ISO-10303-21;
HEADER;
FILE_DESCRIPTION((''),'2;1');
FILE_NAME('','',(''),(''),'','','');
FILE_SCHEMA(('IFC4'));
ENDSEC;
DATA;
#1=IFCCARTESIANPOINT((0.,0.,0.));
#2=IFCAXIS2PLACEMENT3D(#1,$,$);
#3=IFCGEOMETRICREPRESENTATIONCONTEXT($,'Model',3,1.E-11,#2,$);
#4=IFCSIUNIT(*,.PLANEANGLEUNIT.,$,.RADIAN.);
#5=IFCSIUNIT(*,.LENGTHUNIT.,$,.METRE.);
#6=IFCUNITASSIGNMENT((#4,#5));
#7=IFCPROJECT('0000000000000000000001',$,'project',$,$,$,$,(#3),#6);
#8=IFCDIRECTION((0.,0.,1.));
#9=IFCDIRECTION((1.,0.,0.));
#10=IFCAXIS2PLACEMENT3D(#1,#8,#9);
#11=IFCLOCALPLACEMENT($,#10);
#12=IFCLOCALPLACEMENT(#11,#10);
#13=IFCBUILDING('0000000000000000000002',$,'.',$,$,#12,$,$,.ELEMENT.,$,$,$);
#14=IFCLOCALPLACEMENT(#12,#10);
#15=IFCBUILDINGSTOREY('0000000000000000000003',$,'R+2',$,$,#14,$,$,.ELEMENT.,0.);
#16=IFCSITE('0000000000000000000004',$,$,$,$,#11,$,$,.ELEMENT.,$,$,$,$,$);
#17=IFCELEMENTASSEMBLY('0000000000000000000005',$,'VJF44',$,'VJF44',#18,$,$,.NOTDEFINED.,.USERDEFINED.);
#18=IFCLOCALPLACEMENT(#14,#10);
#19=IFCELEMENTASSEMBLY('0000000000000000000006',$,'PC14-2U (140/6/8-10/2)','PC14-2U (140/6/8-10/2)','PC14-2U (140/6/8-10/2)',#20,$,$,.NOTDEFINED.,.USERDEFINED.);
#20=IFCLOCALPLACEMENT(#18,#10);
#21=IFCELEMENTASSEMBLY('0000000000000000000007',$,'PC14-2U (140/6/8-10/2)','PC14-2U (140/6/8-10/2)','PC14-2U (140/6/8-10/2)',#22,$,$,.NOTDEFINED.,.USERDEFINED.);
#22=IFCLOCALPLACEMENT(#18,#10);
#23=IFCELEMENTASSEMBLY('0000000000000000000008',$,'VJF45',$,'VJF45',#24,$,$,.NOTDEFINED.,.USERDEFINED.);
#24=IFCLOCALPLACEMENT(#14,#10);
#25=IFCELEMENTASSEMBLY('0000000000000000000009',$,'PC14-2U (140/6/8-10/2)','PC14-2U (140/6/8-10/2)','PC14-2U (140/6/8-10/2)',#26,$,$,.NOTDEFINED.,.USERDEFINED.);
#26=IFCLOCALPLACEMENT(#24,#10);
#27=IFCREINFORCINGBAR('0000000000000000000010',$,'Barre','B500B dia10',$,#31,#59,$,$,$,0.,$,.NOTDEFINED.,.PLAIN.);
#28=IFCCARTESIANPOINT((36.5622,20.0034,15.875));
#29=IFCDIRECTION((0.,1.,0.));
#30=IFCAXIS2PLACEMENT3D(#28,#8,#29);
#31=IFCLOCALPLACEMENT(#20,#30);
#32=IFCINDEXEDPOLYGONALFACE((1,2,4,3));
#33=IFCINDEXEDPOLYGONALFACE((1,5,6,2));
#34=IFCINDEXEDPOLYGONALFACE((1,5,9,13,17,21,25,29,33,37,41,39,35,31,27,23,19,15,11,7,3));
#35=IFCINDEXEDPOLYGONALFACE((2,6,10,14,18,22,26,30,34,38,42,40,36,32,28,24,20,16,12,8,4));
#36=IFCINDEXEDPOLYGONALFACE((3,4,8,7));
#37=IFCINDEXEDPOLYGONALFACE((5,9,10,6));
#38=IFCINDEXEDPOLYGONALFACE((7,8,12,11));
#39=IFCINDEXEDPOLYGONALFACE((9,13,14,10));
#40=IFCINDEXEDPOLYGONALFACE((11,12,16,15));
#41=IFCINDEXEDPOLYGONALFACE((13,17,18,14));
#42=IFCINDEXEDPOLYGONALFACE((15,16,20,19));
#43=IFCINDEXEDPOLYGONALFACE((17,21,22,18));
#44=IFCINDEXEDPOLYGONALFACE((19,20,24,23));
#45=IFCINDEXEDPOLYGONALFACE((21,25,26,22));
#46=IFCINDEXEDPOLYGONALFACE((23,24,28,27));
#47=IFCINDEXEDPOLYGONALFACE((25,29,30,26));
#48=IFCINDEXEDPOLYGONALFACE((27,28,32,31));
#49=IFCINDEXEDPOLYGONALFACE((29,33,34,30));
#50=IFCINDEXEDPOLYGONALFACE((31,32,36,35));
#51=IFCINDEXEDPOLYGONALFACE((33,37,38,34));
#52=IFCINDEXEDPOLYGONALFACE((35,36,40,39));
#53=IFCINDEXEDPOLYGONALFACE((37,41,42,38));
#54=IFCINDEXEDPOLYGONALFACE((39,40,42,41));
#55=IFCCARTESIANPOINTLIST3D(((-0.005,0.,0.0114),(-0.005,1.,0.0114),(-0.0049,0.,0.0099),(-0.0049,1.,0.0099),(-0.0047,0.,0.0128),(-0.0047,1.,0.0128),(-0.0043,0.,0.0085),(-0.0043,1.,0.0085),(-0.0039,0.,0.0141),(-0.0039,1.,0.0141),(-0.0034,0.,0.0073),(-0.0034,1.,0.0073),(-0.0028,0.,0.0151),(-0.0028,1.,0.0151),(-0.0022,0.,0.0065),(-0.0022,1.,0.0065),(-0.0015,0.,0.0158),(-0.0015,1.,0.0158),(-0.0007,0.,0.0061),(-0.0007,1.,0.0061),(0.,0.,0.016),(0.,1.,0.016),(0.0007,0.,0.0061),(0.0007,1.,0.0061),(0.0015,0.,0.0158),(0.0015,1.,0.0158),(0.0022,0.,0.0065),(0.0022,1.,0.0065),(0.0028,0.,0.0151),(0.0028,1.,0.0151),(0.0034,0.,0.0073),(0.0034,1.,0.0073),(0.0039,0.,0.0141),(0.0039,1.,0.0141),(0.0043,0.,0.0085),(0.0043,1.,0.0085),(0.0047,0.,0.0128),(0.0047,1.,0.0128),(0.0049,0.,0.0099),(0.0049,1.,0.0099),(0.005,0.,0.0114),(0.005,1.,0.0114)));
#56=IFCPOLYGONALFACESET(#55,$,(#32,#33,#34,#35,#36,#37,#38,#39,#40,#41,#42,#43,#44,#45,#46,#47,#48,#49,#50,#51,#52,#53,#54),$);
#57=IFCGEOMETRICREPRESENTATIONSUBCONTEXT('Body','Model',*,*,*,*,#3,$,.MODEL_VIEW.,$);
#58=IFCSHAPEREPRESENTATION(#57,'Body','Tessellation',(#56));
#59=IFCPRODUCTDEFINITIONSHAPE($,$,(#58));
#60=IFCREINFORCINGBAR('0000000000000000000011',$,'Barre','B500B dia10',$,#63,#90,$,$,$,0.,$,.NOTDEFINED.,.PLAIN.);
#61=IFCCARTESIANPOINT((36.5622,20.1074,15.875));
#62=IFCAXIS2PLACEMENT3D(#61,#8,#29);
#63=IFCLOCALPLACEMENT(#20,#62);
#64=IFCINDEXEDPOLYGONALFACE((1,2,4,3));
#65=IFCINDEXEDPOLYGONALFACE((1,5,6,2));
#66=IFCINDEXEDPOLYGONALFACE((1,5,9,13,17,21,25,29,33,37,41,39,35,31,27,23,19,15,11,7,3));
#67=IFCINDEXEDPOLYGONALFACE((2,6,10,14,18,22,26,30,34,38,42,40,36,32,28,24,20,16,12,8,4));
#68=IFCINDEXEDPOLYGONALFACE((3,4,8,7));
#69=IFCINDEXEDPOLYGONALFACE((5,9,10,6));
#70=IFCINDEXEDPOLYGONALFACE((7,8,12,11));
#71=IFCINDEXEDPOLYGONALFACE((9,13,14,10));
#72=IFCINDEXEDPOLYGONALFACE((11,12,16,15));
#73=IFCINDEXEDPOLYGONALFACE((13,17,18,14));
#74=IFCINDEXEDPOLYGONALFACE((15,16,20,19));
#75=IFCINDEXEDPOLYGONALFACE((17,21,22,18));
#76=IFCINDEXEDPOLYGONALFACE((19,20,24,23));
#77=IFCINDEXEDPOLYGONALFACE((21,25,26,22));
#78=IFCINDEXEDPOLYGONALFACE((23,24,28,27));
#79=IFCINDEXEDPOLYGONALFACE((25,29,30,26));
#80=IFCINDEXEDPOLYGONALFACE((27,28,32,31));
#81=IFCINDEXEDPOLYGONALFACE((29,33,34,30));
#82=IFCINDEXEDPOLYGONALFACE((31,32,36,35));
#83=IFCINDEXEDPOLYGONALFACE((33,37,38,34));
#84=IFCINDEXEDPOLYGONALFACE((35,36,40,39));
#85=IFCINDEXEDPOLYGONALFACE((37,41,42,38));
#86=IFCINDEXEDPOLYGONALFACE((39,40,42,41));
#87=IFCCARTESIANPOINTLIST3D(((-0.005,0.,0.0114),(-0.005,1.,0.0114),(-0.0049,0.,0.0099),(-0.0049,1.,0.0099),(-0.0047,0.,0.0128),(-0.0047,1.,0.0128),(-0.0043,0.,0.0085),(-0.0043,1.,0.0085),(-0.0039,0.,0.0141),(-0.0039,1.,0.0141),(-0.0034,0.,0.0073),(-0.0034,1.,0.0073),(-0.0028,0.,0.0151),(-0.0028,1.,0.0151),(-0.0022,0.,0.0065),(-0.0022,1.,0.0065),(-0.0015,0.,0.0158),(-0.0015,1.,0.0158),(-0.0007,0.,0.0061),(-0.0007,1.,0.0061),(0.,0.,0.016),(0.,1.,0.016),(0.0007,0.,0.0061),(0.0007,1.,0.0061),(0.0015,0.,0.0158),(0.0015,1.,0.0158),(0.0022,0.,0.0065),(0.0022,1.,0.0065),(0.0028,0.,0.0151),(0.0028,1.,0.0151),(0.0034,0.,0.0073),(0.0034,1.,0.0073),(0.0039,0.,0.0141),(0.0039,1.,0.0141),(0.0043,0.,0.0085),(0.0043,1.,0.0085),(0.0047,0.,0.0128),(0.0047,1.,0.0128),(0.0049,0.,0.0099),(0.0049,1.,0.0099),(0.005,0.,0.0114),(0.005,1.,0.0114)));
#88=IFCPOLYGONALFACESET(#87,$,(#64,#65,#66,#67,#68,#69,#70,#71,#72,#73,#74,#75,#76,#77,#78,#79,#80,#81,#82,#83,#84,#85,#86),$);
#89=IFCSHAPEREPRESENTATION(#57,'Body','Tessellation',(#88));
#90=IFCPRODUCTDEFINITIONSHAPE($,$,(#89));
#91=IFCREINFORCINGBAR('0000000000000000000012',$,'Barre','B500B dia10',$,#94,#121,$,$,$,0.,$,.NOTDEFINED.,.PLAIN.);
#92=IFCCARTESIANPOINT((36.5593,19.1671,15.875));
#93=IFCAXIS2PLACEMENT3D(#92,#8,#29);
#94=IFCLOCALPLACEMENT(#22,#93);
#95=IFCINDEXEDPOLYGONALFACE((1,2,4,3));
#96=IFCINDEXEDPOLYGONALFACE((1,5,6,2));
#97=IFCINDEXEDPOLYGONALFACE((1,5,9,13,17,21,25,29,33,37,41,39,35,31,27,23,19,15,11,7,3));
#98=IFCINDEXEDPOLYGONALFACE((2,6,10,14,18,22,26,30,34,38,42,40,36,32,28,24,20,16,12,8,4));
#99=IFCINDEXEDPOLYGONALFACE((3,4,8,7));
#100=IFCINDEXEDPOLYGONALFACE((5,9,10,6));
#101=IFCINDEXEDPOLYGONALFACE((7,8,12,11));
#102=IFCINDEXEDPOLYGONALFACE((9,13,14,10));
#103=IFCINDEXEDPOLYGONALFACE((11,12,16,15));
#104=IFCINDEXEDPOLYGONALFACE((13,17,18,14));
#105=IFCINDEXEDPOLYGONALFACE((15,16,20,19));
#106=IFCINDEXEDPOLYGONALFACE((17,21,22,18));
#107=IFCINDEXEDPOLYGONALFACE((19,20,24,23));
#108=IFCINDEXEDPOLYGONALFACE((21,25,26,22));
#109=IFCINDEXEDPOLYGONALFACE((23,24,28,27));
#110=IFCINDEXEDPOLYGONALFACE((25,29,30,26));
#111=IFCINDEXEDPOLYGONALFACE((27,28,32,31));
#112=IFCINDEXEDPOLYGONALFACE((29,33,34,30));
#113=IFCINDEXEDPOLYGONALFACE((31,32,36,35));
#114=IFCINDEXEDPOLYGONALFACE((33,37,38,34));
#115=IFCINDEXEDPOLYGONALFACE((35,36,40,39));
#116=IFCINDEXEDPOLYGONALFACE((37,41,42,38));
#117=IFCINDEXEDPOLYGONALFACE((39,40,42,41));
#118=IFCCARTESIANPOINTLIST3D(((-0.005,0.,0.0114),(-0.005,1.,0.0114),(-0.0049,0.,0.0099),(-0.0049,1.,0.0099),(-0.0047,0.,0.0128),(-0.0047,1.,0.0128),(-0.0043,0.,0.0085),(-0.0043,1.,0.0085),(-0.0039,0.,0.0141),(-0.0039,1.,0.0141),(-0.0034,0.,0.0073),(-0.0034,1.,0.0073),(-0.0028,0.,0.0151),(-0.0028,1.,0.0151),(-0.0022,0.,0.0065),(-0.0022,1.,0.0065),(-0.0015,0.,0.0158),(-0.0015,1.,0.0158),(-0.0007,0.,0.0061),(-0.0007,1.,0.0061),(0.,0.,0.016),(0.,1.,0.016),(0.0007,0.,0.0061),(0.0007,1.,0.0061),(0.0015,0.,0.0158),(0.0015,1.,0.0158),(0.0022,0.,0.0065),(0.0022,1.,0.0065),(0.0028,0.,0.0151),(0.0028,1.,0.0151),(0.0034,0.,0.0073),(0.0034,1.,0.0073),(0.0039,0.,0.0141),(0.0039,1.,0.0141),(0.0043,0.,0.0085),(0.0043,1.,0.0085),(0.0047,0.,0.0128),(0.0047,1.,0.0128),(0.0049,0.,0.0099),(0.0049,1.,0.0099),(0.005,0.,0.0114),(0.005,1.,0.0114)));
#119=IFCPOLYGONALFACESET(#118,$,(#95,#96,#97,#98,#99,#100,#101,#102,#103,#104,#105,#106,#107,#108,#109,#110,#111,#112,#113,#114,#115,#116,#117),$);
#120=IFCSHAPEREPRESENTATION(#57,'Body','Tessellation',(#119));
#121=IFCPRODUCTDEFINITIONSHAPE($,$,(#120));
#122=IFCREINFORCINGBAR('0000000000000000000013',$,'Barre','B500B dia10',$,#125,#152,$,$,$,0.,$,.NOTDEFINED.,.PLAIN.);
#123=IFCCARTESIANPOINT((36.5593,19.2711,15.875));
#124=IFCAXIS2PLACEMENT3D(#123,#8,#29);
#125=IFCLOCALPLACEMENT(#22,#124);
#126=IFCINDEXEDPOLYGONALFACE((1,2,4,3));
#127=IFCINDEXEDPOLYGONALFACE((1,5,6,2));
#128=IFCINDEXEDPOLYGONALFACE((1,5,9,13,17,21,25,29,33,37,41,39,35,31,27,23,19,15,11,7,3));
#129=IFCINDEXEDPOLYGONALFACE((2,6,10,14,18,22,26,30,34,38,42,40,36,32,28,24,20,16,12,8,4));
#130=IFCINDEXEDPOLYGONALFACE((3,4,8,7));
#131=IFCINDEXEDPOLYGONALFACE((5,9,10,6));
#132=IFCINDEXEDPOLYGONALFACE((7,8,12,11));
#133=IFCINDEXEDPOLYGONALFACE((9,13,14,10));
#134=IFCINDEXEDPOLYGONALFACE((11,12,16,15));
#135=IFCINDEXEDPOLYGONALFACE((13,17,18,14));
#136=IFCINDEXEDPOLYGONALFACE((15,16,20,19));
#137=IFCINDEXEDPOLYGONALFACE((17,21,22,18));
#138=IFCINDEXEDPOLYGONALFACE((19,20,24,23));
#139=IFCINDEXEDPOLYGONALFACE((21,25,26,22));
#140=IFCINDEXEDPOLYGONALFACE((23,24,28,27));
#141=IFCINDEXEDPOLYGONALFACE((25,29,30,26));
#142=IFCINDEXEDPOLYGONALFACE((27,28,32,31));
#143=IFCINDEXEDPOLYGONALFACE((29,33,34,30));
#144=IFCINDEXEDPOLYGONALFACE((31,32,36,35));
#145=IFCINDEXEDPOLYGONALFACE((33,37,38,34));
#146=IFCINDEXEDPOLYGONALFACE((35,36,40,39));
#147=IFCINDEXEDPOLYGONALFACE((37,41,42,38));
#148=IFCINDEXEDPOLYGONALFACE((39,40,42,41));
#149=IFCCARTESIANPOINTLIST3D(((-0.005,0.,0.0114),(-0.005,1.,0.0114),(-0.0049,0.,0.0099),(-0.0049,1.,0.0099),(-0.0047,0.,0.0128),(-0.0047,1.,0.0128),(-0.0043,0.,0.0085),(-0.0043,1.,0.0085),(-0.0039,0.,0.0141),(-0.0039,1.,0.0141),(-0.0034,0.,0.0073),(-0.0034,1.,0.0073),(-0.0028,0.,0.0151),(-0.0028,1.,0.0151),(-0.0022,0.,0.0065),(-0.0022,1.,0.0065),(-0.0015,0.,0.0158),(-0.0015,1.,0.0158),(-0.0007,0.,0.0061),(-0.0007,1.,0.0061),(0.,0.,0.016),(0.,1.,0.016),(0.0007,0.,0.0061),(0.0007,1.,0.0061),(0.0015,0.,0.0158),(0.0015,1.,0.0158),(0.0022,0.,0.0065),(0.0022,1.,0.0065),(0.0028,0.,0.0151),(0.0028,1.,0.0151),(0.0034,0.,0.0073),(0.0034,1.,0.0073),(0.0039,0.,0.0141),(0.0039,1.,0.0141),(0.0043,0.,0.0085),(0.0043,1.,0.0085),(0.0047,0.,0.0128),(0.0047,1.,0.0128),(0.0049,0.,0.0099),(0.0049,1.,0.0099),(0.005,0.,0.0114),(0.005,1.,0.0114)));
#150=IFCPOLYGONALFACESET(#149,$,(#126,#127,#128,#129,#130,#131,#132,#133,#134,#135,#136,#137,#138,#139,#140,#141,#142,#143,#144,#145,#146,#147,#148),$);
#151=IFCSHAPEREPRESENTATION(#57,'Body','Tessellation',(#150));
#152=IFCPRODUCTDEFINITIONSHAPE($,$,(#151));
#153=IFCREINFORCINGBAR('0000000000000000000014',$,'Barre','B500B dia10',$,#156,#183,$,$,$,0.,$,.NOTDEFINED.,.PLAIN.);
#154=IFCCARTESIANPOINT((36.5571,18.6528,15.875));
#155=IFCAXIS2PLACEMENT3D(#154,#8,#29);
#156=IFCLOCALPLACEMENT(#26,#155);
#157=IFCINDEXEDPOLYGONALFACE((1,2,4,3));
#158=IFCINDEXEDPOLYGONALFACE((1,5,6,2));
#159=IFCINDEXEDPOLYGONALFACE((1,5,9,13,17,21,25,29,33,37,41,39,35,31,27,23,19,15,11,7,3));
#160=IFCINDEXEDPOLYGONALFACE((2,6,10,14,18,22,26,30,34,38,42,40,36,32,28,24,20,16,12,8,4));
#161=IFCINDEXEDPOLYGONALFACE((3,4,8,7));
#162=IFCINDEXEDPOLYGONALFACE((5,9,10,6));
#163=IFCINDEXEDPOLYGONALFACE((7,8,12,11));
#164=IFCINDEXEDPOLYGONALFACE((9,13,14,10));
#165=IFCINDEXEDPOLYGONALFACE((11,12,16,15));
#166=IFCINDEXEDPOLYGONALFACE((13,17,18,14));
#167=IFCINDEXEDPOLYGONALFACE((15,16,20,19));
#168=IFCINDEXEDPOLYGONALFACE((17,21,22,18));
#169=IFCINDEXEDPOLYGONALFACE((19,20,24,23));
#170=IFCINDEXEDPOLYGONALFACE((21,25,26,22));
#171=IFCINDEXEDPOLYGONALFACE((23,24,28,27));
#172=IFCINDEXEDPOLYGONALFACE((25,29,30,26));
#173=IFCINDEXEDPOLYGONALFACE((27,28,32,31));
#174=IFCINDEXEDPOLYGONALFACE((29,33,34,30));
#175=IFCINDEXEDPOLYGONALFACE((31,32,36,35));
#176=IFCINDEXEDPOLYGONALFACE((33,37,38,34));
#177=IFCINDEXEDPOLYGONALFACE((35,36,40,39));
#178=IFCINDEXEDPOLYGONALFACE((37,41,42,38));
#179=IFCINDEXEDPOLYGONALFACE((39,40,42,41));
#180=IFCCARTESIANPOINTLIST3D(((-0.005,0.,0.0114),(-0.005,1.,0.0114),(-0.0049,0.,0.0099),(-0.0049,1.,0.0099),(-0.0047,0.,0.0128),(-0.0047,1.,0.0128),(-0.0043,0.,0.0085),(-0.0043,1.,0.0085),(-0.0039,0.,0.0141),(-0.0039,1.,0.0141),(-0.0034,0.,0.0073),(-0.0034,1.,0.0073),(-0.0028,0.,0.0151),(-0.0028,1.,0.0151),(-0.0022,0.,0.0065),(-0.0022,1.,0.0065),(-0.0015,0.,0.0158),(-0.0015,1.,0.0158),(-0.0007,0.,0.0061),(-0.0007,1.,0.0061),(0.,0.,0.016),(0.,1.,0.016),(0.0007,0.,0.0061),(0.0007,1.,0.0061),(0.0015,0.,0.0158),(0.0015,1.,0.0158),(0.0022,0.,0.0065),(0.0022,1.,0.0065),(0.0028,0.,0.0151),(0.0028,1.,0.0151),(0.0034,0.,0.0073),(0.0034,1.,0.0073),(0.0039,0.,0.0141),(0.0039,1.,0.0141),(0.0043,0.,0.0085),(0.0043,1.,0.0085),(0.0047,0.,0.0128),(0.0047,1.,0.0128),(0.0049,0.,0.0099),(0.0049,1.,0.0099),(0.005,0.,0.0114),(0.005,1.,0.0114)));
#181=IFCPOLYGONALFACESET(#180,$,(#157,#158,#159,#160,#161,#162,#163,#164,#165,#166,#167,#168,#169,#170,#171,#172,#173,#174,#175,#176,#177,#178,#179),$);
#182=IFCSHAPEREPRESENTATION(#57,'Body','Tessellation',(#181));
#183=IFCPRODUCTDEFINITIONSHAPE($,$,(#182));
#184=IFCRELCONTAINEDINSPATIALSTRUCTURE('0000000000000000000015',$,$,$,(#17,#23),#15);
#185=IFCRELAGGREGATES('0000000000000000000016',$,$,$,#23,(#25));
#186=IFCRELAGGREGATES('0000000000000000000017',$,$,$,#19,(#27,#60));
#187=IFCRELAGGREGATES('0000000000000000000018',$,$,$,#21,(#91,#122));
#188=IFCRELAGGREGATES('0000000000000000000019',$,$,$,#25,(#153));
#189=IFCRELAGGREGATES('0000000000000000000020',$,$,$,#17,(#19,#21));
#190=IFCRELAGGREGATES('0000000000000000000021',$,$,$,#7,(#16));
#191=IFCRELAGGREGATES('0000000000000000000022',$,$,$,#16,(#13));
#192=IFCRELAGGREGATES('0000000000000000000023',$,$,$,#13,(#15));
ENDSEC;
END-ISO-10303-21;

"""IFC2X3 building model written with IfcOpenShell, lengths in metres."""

from ifc_helpers import new_model, entity, si_unit, frame, origin, origin_with_axes, place, context, subcontext, project, spatial, source, transform, mapped, element, aggregate, save


model = new_model("IFC2X3")

# Units and contexts
model_context = context("Model", 3, precision=1e-11, world=origin())
body_context = subcontext(model_context, "Body", "Model", "MODEL_VIEW")
ifc_project = project(units=[si_unit("PLANEANGLEUNIT", "RADIAN"), si_unit("LENGTHUNIT", "METRE")], contexts=[model_context])

# Site, building, storey
site_placement = place(None, origin_with_axes())
site = spatial("IfcSite", under=ifc_project, at=site_placement, CompositionType="ELEMENT")
building_placement = place(site_placement, origin_with_axes())
building = spatial("IfcBuilding", under=site, at=building_placement, Name=".", CompositionType="ELEMENT")
storey_placement = place(building_placement, origin_with_axes())
storey = spatial("IfcBuildingStorey", under=building, at=storey_placement, Name="R+2", CompositionType="ELEMENT", Elevation=0.0)

# Element assemblies
assembly_1_placement = place(storey_placement, origin_with_axes())
assembly_1 = element("IfcElementAssembly", 1, at=assembly_1_placement, inside=storey, Name="VJF44", ObjectType="VJF44", AssemblyPlace="NOTDEFINED", PredefinedType="USERDEFINED")
assembly_2_placement = place(assembly_1_placement, origin_with_axes())
assembly_2 = element("IfcElementAssembly", 2, at=assembly_2_placement, Name="PC14-2U (140/6/8-10/2)", Description="PC14-2U (140/6/8-10/2)", ObjectType="PC14-2U (140/6/8-10/2)", AssemblyPlace="NOTDEFINED", PredefinedType="USERDEFINED")
assembly_3_placement = place(assembly_1_placement, origin_with_axes())
assembly_3 = element("IfcElementAssembly", 3, at=assembly_3_placement, Name="PC14-2U (140/6/8-10/2)", Description="PC14-2U (140/6/8-10/2)", ObjectType="PC14-2U (140/6/8-10/2)", AssemblyPlace="NOTDEFINED", PredefinedType="USERDEFINED")
assembly_4_placement = place(storey_placement, origin_with_axes())
assembly_4 = element("IfcElementAssembly", 4, at=assembly_4_placement, inside=storey, Name="VJF45", ObjectType="VJF45", AssemblyPlace="NOTDEFINED", PredefinedType="USERDEFINED")
assembly_5_placement = place(assembly_4_placement, origin_with_axes())
assembly_5 = element("IfcElementAssembly", 5, at=assembly_5_placement, Name="PC14-2U (140/6/8-10/2)", Description="PC14-2U (140/6/8-10/2)", ObjectType="PC14-2U (140/6/8-10/2)", AssemblyPlace="NOTDEFINED", PredefinedType="USERDEFINED")
aggregate(assembly_4, [assembly_5])

# Reinforcing bars
shared_shape_1 = source(origin_with_axes(), body_context, "Body", "AdvancedSweptSolid", [
    entity("IfcSweptDiskSolid", entity("IfcPolyline", [entity("IfcCartesianPoint", [0.0, 0.0, 0.011]), entity("IfcCartesianPoint", [0.0, 1.0, 0.011])]), 0.005, None, 0.0, 1.0),
])
reinforcing_bar_1_placement = place(assembly_2_placement, frame((36.5622, 20.0034, 15.875), z_axis=(0.0, 0.0, 1.0), x_axis=(0.0, 1.0, 0.0)))
reinforcing_bar_1 = element("IfcReinforcingBar", 6, at=reinforcing_bar_1_placement, Name="Barre", Description="B500B dia10", BarRole="NOTDEFINED", BarSurface="PLAIN", CrossSectionArea=0.0, context=body_context, shape_type="MappedRepresentation", body=[
    mapped(shared_shape_1, transform((0.0, 0.0, 0.0), scale=1.0)),
])
reinforcing_bar_2_placement = place(assembly_2_placement, frame((36.5622, 20.1074, 15.875), z_axis=(0.0, 0.0, 1.0), x_axis=(0.0, 1.0, 0.0)))
reinforcing_bar_2 = element("IfcReinforcingBar", 7, at=reinforcing_bar_2_placement, Name="Barre", Description="B500B dia10", BarRole="NOTDEFINED", BarSurface="PLAIN", CrossSectionArea=0.0, context=body_context, shape_type="MappedRepresentation", body=[
    mapped(shared_shape_1, transform((0.0, 0.0, 0.0), scale=1.0)),
])
aggregate(assembly_2, [reinforcing_bar_1, reinforcing_bar_2])
reinforcing_bar_3_placement = place(assembly_3_placement, frame((36.5593, 19.1671, 15.875), z_axis=(0.0, 0.0, 1.0), x_axis=(0.0, 1.0, 0.0)))
reinforcing_bar_3 = element("IfcReinforcingBar", 8, at=reinforcing_bar_3_placement, Name="Barre", Description="B500B dia10", BarRole="NOTDEFINED", BarSurface="PLAIN", CrossSectionArea=0.0, context=body_context, shape_type="MappedRepresentation", body=[
    mapped(shared_shape_1, transform((0.0, 0.0, 0.0), scale=1.0)),
])
reinforcing_bar_4_placement = place(assembly_3_placement, frame((36.5593, 19.2711, 15.875), z_axis=(0.0, 0.0, 1.0), x_axis=(0.0, 1.0, 0.0)))
reinforcing_bar_4 = element("IfcReinforcingBar", 9, at=reinforcing_bar_4_placement, Name="Barre", Description="B500B dia10", BarRole="NOTDEFINED", BarSurface="PLAIN", CrossSectionArea=0.0, context=body_context, shape_type="MappedRepresentation", body=[
    mapped(shared_shape_1, transform((0.0, 0.0, 0.0), scale=1.0)),
])
aggregate(assembly_3, [reinforcing_bar_3, reinforcing_bar_4])
reinforcing_bar_5_placement = place(assembly_5_placement, frame((36.5571, 18.6528, 15.875), z_axis=(0.0, 0.0, 1.0), x_axis=(0.0, 1.0, 0.0)))
reinforcing_bar_5 = element("IfcReinforcingBar", 10, at=reinforcing_bar_5_placement, Name="Barre", Description="B500B dia10", BarRole="NOTDEFINED", BarSurface="PLAIN", CrossSectionArea=0.0, context=body_context, shape_type="MappedRepresentation", body=[
    mapped(shared_shape_1, transform((0.0, 0.0, 0.0), scale=1.0)),
])
aggregate(assembly_5, [reinforcing_bar_5])
aggregate(assembly_1, [assembly_2, assembly_3])

save(model, "model.ifc")
